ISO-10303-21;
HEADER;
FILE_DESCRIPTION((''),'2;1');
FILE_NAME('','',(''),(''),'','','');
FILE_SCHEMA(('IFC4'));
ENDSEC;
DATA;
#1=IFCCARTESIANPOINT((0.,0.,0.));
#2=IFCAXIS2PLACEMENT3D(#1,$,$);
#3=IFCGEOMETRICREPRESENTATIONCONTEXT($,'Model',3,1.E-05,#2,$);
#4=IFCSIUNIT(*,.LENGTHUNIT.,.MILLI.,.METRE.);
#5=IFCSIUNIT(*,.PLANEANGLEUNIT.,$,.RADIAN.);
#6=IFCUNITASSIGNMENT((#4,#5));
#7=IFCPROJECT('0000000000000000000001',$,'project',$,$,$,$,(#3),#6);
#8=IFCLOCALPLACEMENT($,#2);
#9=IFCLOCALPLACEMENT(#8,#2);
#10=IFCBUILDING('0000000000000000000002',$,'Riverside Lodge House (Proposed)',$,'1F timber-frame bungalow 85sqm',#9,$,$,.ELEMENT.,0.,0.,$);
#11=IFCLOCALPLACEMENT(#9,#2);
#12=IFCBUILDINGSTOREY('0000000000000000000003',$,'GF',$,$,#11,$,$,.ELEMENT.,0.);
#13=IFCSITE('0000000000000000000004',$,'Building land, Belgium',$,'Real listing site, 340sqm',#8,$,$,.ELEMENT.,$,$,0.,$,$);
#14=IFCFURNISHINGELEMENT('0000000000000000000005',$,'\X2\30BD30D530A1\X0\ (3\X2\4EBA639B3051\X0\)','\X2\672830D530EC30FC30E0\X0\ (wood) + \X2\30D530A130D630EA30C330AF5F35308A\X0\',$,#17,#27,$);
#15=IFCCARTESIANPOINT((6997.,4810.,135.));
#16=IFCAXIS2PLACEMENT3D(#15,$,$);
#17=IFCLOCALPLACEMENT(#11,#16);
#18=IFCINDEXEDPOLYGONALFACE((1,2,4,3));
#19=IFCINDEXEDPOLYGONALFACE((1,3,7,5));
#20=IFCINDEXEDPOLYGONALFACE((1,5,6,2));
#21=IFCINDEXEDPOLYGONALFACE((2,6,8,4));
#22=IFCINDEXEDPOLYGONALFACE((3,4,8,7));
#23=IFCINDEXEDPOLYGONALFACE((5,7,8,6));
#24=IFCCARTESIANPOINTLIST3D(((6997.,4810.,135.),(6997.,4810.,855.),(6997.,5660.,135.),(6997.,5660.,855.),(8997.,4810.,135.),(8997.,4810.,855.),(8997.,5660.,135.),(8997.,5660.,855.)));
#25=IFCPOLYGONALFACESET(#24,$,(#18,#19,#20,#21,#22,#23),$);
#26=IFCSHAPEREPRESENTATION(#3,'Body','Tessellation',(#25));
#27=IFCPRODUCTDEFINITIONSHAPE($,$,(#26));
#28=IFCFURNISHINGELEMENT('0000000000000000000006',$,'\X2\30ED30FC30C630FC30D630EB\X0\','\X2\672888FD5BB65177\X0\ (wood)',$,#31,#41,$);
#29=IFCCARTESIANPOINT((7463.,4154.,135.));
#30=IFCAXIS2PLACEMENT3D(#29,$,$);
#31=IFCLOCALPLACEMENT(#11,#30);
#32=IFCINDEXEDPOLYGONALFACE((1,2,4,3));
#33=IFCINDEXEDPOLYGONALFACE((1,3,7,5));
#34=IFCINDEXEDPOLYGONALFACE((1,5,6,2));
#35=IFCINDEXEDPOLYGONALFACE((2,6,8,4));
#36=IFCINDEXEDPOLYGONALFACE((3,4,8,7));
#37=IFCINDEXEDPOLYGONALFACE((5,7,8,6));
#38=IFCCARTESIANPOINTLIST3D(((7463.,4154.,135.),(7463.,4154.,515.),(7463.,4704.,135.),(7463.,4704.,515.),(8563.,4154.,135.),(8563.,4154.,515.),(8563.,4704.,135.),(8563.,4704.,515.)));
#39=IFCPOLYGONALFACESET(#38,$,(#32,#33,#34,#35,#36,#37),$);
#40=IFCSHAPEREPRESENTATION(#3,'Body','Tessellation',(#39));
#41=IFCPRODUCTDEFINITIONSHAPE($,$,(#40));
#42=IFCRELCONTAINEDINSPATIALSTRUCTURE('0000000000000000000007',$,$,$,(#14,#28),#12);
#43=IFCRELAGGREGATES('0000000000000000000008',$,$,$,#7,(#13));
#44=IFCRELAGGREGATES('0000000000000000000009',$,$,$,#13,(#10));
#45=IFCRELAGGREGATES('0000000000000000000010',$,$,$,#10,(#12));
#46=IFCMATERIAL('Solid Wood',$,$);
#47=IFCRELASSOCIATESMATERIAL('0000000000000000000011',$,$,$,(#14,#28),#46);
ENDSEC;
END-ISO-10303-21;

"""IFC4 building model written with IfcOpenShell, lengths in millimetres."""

from ifc_helpers import new_model, si_unit, frame, frame_2d, origin, place, context, project, spatial, rectangle, extrude, material, element, save


model = new_model("IFC4")

# Units and contexts
model_context = context("Model", 3, precision=1e-05, world=origin())
ifc_project = project(units=[si_unit("LENGTHUNIT", "METRE", prefix="MILLI"), si_unit("PLANEANGLEUNIT", "RADIAN")], contexts=[model_context])

# Site, building, storey
site_placement = place(None, origin())
site = spatial("IfcSite", under=ifc_project, at=site_placement, Name="Building land, Belgium", ObjectType="Real listing site, 340sqm", CompositionType="ELEMENT", RefElevation=0.0)
building_placement = place(site_placement, origin())
building = spatial("IfcBuilding", under=site, at=building_placement, Name="Riverside Lodge House (Proposed)", ObjectType="1F timber-frame bungalow 85sqm", CompositionType="ELEMENT", ElevationOfRefHeight=0.0, ElevationOfTerrain=0.0)
storey_placement = place(building_placement, origin())
storey = spatial("IfcBuildingStorey", under=building, at=storey_placement, Name="GF", CompositionType="ELEMENT", Elevation=0.0)

# Shared definitions
ifc_material_1 = material(Name="Solid Wood")

# Furnishing elements
furnishing_1_placement = place(storey_placement, frame((6997.0, 4810.0, 135.0)))
element("IfcFurnishingElement", 1, at=furnishing_1_placement, inside=storey, material=ifc_material_1, Name="ソファ (3人掛け)", Description="木フレーム (wood) + ファブリック張り", context=model_context, shape_type="SweptSolid", body=[
    extrude(rectangle(XDim=2000.0, YDim=850.0, at=frame_2d((1000.0, 425.0))), frame((6997.0, 4810.0, 135.0)), (0.0, 0.0, 1.0), 720.0),
])
furnishing_2_placement = place(storey_placement, frame((7463.0, 4154.0, 135.0)))
element("IfcFurnishingElement", 2, at=furnishing_2_placement, inside=storey, material=ifc_material_1, Name="ローテーブル", Description="木製家具 (wood)", context=model_context, shape_type="SweptSolid", body=[
    extrude(rectangle(XDim=1100.0, YDim=550.0, at=frame_2d((550.0, 275.0))), frame((7463.0, 4154.0, 135.0)), (0.0, 0.0, 1.0), 380.0),
])

save(model, "model.ifc")
